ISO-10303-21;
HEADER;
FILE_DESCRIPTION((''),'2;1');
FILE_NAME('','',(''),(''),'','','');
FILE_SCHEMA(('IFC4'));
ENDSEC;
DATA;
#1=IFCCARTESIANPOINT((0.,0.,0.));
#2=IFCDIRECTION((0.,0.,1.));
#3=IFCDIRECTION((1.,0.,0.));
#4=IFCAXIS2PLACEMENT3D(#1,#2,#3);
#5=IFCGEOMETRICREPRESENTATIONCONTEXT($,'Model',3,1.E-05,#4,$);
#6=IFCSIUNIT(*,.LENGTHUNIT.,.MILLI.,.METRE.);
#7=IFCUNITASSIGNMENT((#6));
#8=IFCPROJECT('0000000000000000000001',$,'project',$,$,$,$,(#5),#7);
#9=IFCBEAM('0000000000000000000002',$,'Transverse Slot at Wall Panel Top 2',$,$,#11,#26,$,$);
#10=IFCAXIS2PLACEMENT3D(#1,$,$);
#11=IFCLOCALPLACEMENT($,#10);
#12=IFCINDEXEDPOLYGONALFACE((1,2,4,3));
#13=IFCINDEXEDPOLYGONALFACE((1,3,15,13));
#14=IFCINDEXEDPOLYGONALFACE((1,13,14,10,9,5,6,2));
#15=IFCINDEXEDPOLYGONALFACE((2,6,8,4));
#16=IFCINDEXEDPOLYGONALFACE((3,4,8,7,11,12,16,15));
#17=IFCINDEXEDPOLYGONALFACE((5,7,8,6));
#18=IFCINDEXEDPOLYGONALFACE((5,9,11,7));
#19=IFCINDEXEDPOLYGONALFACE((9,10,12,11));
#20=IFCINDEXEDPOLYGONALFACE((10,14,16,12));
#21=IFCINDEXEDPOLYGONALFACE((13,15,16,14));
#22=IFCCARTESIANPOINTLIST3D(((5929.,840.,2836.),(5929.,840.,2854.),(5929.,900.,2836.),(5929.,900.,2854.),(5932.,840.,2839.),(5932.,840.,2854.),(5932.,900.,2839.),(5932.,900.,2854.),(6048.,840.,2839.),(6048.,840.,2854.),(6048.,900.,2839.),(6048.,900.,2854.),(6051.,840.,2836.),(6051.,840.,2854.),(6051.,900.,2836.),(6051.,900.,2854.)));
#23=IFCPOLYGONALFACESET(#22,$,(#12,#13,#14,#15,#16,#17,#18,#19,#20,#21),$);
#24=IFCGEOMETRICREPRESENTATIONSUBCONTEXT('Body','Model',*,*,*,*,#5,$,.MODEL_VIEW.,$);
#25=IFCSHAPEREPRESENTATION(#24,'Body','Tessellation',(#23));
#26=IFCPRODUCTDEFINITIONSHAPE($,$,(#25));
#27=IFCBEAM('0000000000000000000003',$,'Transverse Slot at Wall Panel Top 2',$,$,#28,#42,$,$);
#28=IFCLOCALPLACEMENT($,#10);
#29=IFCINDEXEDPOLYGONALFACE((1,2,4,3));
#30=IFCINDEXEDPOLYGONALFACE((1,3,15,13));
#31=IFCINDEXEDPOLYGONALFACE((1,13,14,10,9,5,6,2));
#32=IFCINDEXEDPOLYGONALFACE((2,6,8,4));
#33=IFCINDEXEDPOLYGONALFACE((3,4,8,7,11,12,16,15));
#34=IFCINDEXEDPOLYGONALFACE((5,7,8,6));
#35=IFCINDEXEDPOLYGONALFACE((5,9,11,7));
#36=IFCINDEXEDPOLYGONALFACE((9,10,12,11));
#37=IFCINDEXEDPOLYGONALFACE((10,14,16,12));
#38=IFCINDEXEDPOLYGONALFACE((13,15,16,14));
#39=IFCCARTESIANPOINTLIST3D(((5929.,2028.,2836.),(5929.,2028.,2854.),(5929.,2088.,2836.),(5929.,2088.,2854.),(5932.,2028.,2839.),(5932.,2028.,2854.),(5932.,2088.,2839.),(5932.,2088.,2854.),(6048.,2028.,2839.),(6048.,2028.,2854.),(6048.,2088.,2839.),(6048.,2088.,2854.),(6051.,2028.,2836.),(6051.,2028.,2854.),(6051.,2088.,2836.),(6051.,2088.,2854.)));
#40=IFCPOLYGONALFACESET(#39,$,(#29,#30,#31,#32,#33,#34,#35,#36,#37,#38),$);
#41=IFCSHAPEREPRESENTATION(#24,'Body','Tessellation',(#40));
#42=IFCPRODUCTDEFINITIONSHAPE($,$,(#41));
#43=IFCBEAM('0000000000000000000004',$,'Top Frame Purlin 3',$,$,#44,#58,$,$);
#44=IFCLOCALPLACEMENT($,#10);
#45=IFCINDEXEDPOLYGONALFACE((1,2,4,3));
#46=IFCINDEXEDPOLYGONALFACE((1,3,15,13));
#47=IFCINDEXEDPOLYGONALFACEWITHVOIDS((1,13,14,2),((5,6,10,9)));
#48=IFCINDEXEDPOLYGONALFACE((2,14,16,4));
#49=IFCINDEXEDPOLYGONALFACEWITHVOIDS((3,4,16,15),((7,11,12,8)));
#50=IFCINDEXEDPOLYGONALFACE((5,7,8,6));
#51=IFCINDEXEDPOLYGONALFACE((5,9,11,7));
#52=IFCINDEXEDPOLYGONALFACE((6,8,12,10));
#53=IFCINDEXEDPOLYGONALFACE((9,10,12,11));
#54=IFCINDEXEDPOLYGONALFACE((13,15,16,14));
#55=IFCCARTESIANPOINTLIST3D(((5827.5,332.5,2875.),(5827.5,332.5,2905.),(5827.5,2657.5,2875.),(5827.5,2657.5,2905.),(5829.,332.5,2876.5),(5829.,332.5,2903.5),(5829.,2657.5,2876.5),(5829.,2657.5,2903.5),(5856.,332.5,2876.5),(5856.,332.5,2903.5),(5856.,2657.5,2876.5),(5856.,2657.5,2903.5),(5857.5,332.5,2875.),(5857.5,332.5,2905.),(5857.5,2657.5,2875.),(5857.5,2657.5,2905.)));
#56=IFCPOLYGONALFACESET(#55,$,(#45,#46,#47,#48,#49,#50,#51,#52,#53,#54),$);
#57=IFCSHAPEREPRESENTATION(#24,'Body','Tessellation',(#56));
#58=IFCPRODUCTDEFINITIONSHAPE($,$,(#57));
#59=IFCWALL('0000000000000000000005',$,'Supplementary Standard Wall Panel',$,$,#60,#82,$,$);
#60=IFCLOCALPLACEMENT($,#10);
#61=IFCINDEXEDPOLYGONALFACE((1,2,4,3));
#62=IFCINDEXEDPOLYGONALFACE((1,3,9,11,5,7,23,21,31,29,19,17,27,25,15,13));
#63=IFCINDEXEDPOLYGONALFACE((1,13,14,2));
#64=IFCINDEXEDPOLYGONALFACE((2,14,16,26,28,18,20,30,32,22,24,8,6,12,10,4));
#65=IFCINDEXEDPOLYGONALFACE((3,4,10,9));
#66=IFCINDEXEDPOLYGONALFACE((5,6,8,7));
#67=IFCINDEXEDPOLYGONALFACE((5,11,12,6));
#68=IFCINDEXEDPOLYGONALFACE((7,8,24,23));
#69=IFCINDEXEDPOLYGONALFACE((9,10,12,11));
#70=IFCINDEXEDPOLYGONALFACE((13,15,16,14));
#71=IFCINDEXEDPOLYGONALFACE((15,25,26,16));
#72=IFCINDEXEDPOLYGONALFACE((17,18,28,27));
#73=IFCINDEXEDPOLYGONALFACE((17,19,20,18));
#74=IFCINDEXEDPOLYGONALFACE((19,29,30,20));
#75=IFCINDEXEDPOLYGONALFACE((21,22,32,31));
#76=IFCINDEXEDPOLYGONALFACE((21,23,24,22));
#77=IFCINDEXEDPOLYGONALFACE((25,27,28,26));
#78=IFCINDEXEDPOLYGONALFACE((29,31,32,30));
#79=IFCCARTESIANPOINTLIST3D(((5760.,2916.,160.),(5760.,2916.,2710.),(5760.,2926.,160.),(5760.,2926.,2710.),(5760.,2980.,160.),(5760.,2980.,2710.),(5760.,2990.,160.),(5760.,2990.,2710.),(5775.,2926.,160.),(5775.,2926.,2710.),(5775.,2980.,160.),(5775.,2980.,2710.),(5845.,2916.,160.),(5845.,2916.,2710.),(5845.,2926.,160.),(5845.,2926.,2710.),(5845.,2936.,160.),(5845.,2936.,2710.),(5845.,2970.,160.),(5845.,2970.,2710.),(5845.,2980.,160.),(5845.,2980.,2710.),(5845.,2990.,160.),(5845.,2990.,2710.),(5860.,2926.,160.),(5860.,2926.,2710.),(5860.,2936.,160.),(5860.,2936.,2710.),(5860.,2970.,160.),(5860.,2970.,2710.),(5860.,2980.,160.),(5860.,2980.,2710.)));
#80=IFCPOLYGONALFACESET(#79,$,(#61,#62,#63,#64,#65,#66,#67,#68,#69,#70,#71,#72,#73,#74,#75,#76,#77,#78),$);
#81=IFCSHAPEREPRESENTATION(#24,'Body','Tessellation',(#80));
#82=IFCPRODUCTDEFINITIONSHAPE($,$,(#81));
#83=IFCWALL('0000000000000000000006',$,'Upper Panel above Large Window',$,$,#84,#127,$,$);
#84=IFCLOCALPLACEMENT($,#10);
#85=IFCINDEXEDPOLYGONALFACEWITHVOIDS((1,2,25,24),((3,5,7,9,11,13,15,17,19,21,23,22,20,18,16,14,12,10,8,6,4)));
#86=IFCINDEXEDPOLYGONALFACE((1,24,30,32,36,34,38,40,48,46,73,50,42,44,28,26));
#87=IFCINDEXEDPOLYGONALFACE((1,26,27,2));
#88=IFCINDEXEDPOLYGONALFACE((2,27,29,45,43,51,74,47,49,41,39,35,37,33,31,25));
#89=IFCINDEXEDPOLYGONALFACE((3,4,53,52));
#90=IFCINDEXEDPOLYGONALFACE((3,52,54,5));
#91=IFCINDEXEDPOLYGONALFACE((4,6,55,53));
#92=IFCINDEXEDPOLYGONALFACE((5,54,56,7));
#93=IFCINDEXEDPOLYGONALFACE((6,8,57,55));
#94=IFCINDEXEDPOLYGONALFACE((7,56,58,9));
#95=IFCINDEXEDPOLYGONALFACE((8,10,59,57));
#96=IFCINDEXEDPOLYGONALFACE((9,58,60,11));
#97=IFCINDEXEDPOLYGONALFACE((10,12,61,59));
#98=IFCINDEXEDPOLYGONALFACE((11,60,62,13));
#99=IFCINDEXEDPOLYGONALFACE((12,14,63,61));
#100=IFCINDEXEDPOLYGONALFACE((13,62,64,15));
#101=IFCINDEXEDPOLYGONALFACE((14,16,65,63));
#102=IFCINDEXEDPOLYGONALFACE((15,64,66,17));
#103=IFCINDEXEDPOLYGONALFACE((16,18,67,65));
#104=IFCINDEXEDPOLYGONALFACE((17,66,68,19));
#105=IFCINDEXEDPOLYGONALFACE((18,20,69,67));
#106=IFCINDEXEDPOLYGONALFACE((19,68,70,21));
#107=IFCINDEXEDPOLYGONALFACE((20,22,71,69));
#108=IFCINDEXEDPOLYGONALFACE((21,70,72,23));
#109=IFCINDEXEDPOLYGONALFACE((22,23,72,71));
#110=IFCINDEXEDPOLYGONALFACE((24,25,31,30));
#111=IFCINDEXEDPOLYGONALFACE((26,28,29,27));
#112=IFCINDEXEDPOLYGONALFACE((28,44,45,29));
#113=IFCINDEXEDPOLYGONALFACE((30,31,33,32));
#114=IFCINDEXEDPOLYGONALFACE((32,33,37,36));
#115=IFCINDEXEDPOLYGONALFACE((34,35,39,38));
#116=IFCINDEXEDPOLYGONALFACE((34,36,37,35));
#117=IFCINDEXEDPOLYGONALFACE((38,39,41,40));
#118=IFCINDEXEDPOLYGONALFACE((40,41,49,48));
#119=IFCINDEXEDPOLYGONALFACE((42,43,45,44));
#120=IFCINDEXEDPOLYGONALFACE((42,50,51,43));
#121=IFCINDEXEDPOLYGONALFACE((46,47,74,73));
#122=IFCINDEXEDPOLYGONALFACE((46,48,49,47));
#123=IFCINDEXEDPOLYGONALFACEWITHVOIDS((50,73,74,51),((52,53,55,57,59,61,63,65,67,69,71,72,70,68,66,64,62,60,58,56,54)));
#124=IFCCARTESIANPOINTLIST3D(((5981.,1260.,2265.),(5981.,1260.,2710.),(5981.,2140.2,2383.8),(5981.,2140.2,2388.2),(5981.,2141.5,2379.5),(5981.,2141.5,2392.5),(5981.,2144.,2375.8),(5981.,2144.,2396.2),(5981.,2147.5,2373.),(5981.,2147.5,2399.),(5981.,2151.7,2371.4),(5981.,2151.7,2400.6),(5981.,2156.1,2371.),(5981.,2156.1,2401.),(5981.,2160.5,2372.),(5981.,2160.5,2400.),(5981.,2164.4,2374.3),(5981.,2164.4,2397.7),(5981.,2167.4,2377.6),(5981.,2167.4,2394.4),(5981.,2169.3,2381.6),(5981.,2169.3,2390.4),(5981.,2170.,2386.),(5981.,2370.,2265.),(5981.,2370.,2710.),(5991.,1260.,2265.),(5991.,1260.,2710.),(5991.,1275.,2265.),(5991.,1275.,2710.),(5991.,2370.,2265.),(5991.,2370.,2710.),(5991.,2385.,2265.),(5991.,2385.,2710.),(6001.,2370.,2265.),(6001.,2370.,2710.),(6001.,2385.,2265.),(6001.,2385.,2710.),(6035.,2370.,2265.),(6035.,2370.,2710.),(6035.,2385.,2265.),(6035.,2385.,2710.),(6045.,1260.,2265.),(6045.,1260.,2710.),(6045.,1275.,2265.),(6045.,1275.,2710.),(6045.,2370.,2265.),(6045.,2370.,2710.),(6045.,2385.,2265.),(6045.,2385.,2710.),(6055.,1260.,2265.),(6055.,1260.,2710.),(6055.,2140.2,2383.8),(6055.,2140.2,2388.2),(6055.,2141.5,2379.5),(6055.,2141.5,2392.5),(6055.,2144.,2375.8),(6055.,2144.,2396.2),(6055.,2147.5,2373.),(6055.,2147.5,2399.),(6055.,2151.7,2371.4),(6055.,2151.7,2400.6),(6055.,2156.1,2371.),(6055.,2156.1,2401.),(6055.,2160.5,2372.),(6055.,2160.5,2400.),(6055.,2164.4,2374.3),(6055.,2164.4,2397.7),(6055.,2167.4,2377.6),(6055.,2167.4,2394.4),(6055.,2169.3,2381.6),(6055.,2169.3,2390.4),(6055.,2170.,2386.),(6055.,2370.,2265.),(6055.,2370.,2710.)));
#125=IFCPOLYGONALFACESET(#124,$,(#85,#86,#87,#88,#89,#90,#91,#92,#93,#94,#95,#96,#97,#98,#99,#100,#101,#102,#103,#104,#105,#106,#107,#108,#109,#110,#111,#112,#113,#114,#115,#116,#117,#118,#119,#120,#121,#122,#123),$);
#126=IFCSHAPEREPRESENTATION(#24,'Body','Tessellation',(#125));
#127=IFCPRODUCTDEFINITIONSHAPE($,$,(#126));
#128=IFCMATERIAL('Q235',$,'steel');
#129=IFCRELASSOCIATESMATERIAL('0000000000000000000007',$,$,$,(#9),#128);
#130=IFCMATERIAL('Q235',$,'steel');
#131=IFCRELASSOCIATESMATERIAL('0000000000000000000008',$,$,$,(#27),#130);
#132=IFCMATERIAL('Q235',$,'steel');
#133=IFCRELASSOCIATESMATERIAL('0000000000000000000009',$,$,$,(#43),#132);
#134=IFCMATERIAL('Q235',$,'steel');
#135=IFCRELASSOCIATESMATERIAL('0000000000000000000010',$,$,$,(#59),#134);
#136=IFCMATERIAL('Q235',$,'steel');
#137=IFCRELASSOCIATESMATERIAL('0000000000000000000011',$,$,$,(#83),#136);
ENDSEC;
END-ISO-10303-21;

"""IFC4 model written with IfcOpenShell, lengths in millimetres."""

from ifc_helpers import new_model, si_unit, frame, origin_with_axes, origin_2d, place, context, subcontext, project, line, indexed_curve, circle_curve, outline, extrude, material, element, save


model = new_model("IFC4")

# Units and contexts
model_context = context("Model", 3, precision=1e-05, world=origin_with_axes())
body_context = subcontext(model_context, "Body", "Model", "MODEL_VIEW")
ifc_project = project(units=[si_unit("LENGTHUNIT", "METRE", prefix="MILLI")], contexts=[model_context])

# Beams
ifc_material_1 = material(Name="Q235", Category="steel")
beam_1_placement = place(None, frame((6051.0, 840.0, 2836.0), z_axis=(0.0, 1.0, 0.0), x_axis=(0.0, 0.0, -1.0)))
element("IfcBeam", 1, at=beam_1_placement, material=ifc_material_1, Name="Transverse Slot at Wall Panel Top 2", context=body_context, shape_type="SweptSolid", body=[
    extrude(outline(indexed_curve([(0.0, 0.0), (0.0, 122.0), (-18.0, 122.0), (-18.0, 119.0), (-3.0, 119.0), (-3.0, 3.0), (-18.0, 3.0), (-18.0, 0.0), (0.0, 0.0)], segments=[line(1, 2, 3, 4, 5, 6, 7, 8, 9, 1)])), origin_with_axes(), (0.0, 0.0, 1.0), 60.0),
])
ifc_material_2 = material(Name="Q235", Category="steel")
beam_2_placement = place(None, frame((6051.0, 2028.0, 2836.0), z_axis=(0.0, 1.0, 0.0), x_axis=(0.0, 0.0, -1.0)))
element("IfcBeam", 2, at=beam_2_placement, material=ifc_material_2, Name="Transverse Slot at Wall Panel Top 2", context=body_context, shape_type="SweptSolid", body=[
    extrude(outline(indexed_curve([(0.0, 0.0), (0.0, 122.0), (-18.0, 122.0), (-18.0, 119.0), (-3.0, 119.0), (-3.0, 3.0), (-18.0, 3.0), (-18.0, 0.0), (0.0, 0.0)], segments=[line(1, 2, 3, 4, 5, 6, 7, 8, 9, 1)])), origin_with_axes(), (0.0, 0.0, 1.0), 60.0),
])

# Beam, opening
ifc_material_3 = material(Name="Q235", Category="steel")
beam_3_placement = place(None, frame((5827.5, 332.5, 2875.0), z_axis=(0.0, 1.0, 0.0), x_axis=(1.0, 0.0, 0.0)))
beam_3 = element("IfcBeam", 3, at=beam_3_placement, material=ifc_material_3, Name="Top Frame Purlin 3", context=body_context, shape_type="SweptSolid", body=[
    extrude(outline(indexed_curve([(0.0, 0.0), (0.0, -30.0), (30.0, -30.0), (30.0, 0.0), (0.0, 0.0)], segments=[line(1, 2, 3, 4, 5, 1)])), origin_with_axes(), (0.0, 0.0, 1.0), 2325.0),
])
opening_1_placement = place(beam_3_placement, frame((1.5, -1.5, 0.0), z_axis=(0.0, 0.0, 1.0), x_axis=(1.0, 0.0, 0.0)))
element("IfcOpeningElement", 4, at=opening_1_placement, cuts=beam_3, context=body_context, shape_type="SweptSolid", body=[
    extrude(outline(indexed_curve([(0.0, 0.0), (0.0, -27.0), (27.0, -27.0), (27.0, 0.0)], segments=[line(1, 2, 3, 4, 1)])), origin_with_axes(), (0.0, 0.0, 1.0), 2325.0),
])

# Wall
ifc_material_4 = material(Name="Q235", Category="steel")
wall_1_placement = place(None, frame((5760.0, 2916.0, 160.0), z_axis=(0.0, 0.0, 1.0), x_axis=(1.0, 0.0, 0.0)))
element("IfcWall", 5, at=wall_1_placement, material=ifc_material_4, Name="Supplementary Standard Wall Panel", context=body_context, shape_type="SweptSolid", body=[
    extrude(outline(indexed_curve([(0.0, 0.0), (0.0, 10.0), (15.0, 10.0), (15.0, 64.0), (0.0, 64.0), (0.0, 74.0), (85.0, 74.0), (85.0, 64.0), (100.0, 64.0), (100.0, 54.0), (85.0, 54.0), (85.0, 20.0), (100.0, 20.0), (100.0, 10.0), (85.0, 10.0), (85.0, 0.0), (0.0, 0.0)], segments=[line(1, 2, 3, 4, 5, 6, 7, 8, 9, 10, 11, 12, 13, 14, 15, 16, 17, 1)])), origin_with_axes(), (0.0, 0.0, 1.0), 2550.0),
])

# Wall, opening
ifc_material_5 = material(Name="Q235", Category="steel")
wall_2_placement = place(None, frame((6055.0, 1260.0, 2265.0), z_axis=(0.0, 0.0, 1.0), x_axis=(0.0, 1.0, 0.0)))
wall_2 = element("IfcWall", 6, at=wall_2_placement, material=ifc_material_5, Name="Upper Panel above Large Window", context=body_context, shape_type="SweptSolid", body=[
    extrude(outline(indexed_curve([(0.0, 0.0), (0.0, 10.0), (15.0, 10.0), (15.0, 64.0), (0.0, 64.0), (0.0, 74.0), (1110.0, 74.0), (1110.0, 64.0), (1125.0, 64.0), (1125.0, 54.0), (1125.0, 54.0), (1110.0, 54.0), (1110.0, 20.0), (1125.0, 20.0), (1125.0, 10.0), (1110.0, 10.0), (1110.0, 0.0), (0.0, 0.0)], segments=[line(1, 2, 3, 4, 5, 6, 7, 8, 9, 10, 11, 12, 13, 14, 15, 16, 17, 18, 1)])), origin_with_axes(), (0.0, 0.0, 1.0), 445.0),
])
opening_2_placement = place(wall_2_placement, frame((895.0, 0.0, 121.0), z_axis=(0.0, 1.0, 0.0), x_axis=(1.0, 0.0, 0.0)))
element("IfcOpeningElement", 7, at=opening_2_placement, cuts=wall_2, context=body_context, shape_type="SweptSolid", body=[
    extrude(outline(circle_curve(origin_2d(), 15.0)), origin_with_axes(), (0.0, 0.0, 1.0), 74.0),
])

save(model, "model.ifc")
